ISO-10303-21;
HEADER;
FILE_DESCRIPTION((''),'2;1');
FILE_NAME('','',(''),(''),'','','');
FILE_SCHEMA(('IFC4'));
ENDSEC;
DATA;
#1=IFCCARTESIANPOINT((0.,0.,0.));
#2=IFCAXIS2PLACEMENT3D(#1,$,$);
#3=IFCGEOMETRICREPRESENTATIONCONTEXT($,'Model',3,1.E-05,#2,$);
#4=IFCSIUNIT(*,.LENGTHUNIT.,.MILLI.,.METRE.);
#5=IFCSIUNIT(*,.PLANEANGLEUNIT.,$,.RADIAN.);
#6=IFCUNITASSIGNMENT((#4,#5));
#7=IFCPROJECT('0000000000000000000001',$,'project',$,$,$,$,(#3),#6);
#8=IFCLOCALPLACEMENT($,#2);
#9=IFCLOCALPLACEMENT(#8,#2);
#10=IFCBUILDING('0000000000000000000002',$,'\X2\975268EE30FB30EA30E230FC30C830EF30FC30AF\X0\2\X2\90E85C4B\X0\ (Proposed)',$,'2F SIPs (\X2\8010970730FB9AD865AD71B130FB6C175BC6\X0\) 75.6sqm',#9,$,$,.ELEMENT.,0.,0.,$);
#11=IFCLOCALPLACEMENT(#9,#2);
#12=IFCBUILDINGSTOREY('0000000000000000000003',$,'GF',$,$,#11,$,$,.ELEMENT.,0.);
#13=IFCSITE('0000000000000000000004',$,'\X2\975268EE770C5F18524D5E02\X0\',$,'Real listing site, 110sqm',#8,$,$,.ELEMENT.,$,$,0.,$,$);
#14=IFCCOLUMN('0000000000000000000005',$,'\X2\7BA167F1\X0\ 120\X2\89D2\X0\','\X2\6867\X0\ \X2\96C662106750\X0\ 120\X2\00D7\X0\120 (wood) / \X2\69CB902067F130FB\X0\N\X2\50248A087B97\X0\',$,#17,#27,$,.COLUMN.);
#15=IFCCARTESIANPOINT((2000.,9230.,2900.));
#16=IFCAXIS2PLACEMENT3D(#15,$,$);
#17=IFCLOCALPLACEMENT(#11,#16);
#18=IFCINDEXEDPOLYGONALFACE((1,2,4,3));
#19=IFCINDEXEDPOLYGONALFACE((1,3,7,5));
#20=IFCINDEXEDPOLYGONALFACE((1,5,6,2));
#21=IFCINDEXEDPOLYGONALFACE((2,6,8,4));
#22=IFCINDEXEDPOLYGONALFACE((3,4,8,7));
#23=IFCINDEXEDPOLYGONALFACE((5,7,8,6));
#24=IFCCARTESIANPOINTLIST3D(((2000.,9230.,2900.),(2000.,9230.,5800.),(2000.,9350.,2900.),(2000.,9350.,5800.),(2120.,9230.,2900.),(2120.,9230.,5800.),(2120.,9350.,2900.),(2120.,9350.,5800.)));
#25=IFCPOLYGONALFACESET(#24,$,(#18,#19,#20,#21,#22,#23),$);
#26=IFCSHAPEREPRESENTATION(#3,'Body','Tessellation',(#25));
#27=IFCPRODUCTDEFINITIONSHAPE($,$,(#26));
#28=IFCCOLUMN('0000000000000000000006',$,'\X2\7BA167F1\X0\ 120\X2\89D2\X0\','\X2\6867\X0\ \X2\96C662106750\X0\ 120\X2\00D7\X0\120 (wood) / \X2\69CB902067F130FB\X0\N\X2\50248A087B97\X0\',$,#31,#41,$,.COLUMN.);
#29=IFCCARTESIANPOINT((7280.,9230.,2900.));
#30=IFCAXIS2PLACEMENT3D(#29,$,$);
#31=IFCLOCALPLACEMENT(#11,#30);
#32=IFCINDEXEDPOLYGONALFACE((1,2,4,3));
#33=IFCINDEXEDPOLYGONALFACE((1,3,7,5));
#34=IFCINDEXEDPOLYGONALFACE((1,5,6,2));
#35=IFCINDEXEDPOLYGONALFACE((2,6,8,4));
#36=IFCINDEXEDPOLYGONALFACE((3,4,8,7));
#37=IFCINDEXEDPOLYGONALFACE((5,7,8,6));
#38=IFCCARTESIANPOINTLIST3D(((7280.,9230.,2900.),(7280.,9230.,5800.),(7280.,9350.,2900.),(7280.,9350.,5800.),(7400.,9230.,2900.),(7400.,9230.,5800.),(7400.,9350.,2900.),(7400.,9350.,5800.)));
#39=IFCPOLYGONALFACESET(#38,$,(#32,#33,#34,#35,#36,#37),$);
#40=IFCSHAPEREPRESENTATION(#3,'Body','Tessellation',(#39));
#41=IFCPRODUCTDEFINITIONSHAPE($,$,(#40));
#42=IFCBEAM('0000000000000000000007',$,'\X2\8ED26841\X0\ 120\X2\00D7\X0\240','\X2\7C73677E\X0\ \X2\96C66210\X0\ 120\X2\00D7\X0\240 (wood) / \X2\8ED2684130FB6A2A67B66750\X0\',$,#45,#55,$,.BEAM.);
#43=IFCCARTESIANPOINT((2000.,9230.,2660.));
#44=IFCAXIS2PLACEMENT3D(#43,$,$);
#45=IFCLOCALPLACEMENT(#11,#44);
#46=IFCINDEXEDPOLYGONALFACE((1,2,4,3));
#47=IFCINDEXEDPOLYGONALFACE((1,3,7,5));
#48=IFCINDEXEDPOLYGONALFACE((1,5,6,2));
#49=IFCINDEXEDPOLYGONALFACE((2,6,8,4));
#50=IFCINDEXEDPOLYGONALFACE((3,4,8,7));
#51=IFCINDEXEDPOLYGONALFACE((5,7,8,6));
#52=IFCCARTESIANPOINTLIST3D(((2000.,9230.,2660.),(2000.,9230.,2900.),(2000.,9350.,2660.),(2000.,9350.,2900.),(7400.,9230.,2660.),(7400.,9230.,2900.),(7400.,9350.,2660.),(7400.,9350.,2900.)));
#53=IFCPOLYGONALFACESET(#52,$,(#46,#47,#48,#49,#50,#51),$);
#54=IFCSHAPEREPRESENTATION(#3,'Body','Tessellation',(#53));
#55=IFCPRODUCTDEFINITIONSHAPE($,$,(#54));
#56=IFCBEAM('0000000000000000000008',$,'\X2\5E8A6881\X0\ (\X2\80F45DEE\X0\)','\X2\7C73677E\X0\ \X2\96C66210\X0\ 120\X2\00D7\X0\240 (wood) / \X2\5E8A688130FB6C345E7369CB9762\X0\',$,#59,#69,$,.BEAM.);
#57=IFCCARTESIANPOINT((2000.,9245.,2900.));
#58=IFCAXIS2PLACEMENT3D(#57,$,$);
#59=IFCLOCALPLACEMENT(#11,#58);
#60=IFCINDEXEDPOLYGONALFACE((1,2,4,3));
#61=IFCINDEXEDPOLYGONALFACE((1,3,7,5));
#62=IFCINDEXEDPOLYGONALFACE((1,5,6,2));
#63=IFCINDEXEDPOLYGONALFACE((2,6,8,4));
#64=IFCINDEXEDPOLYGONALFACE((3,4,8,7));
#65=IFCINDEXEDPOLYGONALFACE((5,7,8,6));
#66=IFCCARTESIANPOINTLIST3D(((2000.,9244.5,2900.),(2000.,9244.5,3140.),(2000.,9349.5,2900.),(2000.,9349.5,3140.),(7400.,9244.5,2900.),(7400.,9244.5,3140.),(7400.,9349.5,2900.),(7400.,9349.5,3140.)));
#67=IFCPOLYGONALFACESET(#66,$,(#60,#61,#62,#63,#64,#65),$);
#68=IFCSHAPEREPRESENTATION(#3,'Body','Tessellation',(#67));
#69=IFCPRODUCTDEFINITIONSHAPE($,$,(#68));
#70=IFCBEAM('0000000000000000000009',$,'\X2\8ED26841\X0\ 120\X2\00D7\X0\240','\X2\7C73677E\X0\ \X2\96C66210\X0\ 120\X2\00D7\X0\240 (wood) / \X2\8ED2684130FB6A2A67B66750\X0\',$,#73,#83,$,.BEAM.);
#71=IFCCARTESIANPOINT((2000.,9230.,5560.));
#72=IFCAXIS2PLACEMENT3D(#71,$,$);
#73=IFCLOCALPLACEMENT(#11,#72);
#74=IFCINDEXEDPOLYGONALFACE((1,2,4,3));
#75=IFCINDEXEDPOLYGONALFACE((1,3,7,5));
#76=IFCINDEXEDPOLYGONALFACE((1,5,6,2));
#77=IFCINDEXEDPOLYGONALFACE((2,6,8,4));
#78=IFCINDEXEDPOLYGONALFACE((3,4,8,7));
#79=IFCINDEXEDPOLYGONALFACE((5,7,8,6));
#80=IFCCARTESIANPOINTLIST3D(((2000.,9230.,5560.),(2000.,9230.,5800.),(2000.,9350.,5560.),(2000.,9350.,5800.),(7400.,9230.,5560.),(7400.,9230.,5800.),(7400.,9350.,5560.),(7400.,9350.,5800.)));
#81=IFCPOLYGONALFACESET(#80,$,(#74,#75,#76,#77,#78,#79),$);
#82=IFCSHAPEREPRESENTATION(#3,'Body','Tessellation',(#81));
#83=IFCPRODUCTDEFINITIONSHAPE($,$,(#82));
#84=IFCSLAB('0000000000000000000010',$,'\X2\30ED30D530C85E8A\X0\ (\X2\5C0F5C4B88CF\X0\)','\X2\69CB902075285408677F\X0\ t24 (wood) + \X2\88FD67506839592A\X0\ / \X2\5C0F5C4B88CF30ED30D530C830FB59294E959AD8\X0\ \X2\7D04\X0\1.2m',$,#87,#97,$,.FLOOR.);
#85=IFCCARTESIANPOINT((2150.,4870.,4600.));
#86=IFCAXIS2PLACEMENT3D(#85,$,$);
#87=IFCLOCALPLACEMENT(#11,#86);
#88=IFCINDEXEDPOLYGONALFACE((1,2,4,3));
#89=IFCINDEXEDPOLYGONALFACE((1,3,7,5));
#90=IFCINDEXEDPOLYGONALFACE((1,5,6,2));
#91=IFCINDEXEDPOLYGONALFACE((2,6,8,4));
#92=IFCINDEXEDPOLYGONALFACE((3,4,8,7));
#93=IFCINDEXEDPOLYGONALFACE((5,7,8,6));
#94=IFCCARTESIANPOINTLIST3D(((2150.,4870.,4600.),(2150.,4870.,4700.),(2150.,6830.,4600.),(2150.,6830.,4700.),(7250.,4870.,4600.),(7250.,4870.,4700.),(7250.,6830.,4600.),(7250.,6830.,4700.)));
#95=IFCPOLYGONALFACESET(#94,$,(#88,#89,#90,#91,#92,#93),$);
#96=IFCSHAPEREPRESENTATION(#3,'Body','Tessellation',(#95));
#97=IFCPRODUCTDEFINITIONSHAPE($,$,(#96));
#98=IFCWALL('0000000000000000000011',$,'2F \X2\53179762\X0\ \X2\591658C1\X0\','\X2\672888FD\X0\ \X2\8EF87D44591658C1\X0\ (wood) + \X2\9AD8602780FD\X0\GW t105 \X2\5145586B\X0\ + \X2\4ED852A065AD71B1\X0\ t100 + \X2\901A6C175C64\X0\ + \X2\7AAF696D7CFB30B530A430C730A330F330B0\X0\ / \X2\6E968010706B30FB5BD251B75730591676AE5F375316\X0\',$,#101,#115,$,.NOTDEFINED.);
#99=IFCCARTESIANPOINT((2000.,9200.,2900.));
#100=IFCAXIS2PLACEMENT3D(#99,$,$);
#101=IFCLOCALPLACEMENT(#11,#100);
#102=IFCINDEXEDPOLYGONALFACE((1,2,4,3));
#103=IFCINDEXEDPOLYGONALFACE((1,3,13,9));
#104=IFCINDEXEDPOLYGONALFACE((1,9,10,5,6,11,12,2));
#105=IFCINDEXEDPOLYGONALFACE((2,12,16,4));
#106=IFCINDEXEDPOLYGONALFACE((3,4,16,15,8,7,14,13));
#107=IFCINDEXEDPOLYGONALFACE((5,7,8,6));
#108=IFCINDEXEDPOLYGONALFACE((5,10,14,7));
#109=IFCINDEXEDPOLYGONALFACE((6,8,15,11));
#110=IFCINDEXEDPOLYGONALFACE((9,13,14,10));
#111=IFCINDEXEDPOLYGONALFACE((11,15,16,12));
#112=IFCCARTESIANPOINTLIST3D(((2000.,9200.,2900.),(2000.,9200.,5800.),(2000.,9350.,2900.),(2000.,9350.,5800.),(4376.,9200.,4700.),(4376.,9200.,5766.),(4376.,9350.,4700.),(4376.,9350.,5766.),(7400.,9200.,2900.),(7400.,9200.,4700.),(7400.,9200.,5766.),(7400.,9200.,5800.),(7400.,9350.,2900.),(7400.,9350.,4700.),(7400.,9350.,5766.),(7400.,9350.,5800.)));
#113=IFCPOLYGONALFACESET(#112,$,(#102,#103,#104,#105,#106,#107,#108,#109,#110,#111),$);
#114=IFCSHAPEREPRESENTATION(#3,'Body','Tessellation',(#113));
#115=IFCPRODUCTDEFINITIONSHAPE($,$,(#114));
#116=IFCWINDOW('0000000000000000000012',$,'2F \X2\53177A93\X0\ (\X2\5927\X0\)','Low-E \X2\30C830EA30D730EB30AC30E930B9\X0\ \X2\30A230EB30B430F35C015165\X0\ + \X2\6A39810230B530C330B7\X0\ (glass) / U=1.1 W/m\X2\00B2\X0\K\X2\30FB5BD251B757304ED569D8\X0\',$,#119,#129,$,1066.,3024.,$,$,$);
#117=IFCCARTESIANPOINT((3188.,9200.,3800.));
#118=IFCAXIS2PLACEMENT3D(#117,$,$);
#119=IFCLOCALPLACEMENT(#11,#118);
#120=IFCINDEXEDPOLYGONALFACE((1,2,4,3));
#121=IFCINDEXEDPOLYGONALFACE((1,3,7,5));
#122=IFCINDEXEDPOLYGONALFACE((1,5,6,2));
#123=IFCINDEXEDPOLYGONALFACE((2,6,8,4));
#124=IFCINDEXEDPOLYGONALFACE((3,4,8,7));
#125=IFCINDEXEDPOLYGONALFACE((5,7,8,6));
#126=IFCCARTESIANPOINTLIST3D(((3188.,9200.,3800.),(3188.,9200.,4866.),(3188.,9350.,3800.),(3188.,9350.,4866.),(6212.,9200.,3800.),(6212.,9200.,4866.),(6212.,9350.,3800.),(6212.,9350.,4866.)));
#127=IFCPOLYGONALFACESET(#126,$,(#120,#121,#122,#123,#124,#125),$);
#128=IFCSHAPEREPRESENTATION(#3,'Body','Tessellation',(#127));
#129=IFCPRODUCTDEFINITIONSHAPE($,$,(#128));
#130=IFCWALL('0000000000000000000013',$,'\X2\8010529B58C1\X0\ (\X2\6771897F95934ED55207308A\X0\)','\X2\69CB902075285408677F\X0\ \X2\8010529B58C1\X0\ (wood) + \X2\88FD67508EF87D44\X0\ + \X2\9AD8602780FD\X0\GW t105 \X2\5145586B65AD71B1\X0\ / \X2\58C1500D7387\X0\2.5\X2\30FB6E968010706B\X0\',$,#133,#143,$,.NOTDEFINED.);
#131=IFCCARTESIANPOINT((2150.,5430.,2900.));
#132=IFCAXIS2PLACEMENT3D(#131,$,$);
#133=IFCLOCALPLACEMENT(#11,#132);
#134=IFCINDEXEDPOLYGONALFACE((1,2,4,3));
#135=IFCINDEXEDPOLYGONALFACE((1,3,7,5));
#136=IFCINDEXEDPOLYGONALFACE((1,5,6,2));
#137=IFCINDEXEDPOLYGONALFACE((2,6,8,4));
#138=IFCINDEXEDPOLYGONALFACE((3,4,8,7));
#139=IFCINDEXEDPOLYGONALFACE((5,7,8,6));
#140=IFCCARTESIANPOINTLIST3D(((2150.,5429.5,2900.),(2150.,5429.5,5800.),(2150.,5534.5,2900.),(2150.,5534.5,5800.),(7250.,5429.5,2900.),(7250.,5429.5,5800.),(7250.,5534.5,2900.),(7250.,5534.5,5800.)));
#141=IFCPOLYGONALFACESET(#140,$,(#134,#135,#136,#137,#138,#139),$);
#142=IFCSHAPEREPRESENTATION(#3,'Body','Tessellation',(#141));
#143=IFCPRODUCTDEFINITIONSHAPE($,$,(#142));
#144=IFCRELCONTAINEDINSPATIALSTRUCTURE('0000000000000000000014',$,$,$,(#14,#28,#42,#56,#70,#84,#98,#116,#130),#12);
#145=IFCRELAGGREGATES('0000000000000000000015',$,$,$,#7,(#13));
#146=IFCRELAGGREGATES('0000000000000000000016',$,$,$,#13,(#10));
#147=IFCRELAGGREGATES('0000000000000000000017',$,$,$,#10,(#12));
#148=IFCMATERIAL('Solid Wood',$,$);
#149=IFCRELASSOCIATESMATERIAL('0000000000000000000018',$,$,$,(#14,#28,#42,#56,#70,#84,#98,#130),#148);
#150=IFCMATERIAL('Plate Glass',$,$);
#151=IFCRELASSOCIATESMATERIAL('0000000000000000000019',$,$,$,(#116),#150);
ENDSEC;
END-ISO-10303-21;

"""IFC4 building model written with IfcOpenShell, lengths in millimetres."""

from ifc_helpers import new_model, si_unit, frame, frame_2d, origin, place, context, project, spatial, rectangle, extrude, material, element, fill, save


model = new_model("IFC4")

# Units and contexts
model_context = context("Model", 3, precision=1e-05, world=origin())
ifc_project = project(units=[si_unit("LENGTHUNIT", "METRE", prefix="MILLI"), si_unit("PLANEANGLEUNIT", "RADIAN")], contexts=[model_context])

# Site, building, storey
site_placement = place(None, origin())
site = spatial("IfcSite", under=ifc_project, at=site_placement, Name="青森県弘前市", ObjectType="Real listing site, 110sqm", CompositionType="ELEMENT", RefElevation=0.0)
building_placement = place(site_placement, origin())
building = spatial("IfcBuilding", under=site, at=building_placement, Name="青森・リモートワーク2部屋 (Proposed)", ObjectType="2F SIPs (耐震・高断熱・気密) 75.6sqm", CompositionType="ELEMENT", ElevationOfRefHeight=0.0, ElevationOfTerrain=0.0)
storey_placement = place(building_placement, origin())
storey = spatial("IfcBuildingStorey", under=building, at=storey_placement, Name="GF", CompositionType="ELEMENT", Elevation=0.0)

# Columns
ifc_material_1 = material(Name="Solid Wood")
column_1_placement = place(storey_placement, frame((2000.0, 9230.0, 2900.0)))
element("IfcColumn", 1, at=column_1_placement, inside=storey, material=ifc_material_1, Name="管柱 120角", Description="桧 集成材 120×120 (wood) / 構造柱・N値計算", PredefinedType="COLUMN", context=model_context, shape_type="SweptSolid", body=[
    extrude(rectangle(XDim=120.0, YDim=120.0, at=frame_2d((60.0, 60.0))), frame((2000.0, 9230.0, 2900.0)), (0.0, 0.0, 1.0), 2900.0),
])
column_2_placement = place(storey_placement, frame((7280.0, 9230.0, 2900.0)))
element("IfcColumn", 2, at=column_2_placement, inside=storey, material=ifc_material_1, Name="管柱 120角", Description="桧 集成材 120×120 (wood) / 構造柱・N値計算", PredefinedType="COLUMN", context=model_context, shape_type="SweptSolid", body=[
    extrude(rectangle(XDim=120.0, YDim=120.0, at=frame_2d((60.0, 60.0))), frame((7280.0, 9230.0, 2900.0)), (0.0, 0.0, 1.0), 2900.0),
])

# Beams
beam_1_placement = place(storey_placement, frame((2000.0, 9230.0, 2660.0)))
element("IfcBeam", 3, at=beam_1_placement, inside=storey, material=ifc_material_1, Name="軒桁 120×240", Description="米松 集成 120×240 (wood) / 軒桁・横架材", PredefinedType="BEAM", context=model_context, shape_type="SweptSolid", body=[
    extrude(rectangle(XDim=5400.0, YDim=120.0, at=frame_2d((2700.0, 60.0))), frame((2000.0, 9230.0, 2660.0)), (0.0, 0.0, 1.0), 240.0),
])
beam_2_placement = place(storey_placement, frame((2000.0, 9245.0, 2900.0)))
element("IfcBeam", 4, at=beam_2_placement, inside=storey, material=ifc_material_1, Name="床梁 (胴差)", Description="米松 集成 120×240 (wood) / 床梁・水平構面", PredefinedType="BEAM", context=model_context, shape_type="SweptSolid", body=[
    extrude(rectangle(XDim=5400.0, YDim=105.0, at=frame_2d((2700.0, 52.0))), frame((2000.0, 9245.0, 2900.0)), (0.0, 0.0, 1.0), 240.0),
])
beam_3_placement = place(storey_placement, frame((2000.0, 9230.0, 5560.0)))
element("IfcBeam", 5, at=beam_3_placement, inside=storey, material=ifc_material_1, Name="軒桁 120×240", Description="米松 集成 120×240 (wood) / 軒桁・横架材", PredefinedType="BEAM", context=model_context, shape_type="SweptSolid", body=[
    extrude(rectangle(XDim=5400.0, YDim=120.0, at=frame_2d((2700.0, 60.0))), frame((2000.0, 9230.0, 5560.0)), (0.0, 0.0, 1.0), 240.0),
])

# Slab
slab_placement = place(storey_placement, frame((2150.0, 4870.0, 4600.0)))
element("IfcSlab", 6, at=slab_placement, inside=storey, material=ifc_material_1, Name="ロフト床 (小屋裏)", Description="構造用合板 t24 (wood) + 製材根太 / 小屋裏ロフト・天井高 約1.2m", PredefinedType="FLOOR", context=model_context, shape_type="SweptSolid", body=[
    extrude(rectangle(XDim=5100.0, YDim=1960.0, at=frame_2d((2550.0, 980.0))), frame((2150.0, 4870.0, 4600.0)), (0.0, 0.0, 1.0), 100.0),
])

# Wall, opening, window
wall_1_placement = place(storey_placement, frame((2000.0, 9200.0, 2900.0)))
wall_1 = element("IfcWall", 7, at=wall_1_placement, inside=storey, material=ifc_material_1, Name="2F 北面 外壁", Description="木製 軸組外壁 (wood) + 高性能GW t105 充填 + 付加断熱 t100 + 通気層 + 窯業系サイディング / 準耐火・寒冷地外皮強化", PredefinedType="NOTDEFINED", context=model_context, shape_type="SweptSolid", body=[
    extrude(rectangle(XDim=5400.0, YDim=150.0, at=frame_2d((2700.0, 75.0))), frame((2000.0, 9200.0, 2900.0)), (0.0, 0.0, 1.0), 2900.0),
])
opening_1_placement = place(storey_placement, frame((3188.0, 9200.0, 3800.0)))
opening_1 = element("IfcOpeningElement", 8, at=opening_1_placement, cuts=wall_1, PredefinedType="NOTDEFINED", context=model_context, shape_type="SweptSolid", body=[
    extrude(rectangle(XDim=3024.0, YDim=150.0, at=frame_2d((1512.0, 75.0))), frame((3188.0, 9200.0, 3800.0)), (0.0, 0.0, 1.0), 1066.0),
])
ifc_material_2 = material(Name="Plate Glass")
window_1_placement = place(storey_placement, frame((3188.0, 9200.0, 3800.0)))
window_1 = element("IfcWindow", 9, at=window_1_placement, inside=storey, material=ifc_material_2, Name="2F 北窓 (大)", Description="Low-E トリプルガラス アルゴン封入 + 樹脂サッシ (glass) / U=1.1 W/m²K・寒冷地仕様", OverallHeight=1066.0, OverallWidth=3024.0, context=model_context, shape_type="SweptSolid", body=[
    extrude(rectangle(XDim=3024.0, YDim=150.0, at=frame_2d((1512.0, 75.0))), frame((3188.0, 9200.0, 3800.0)), (0.0, 0.0, 1.0), 1066.0),
])
fill(opening_1, window_1)

# Wall
wall_2_placement = place(storey_placement, frame((2150.0, 5430.0, 2900.0)))
element("IfcWall", 10, at=wall_2_placement, inside=storey, material=ifc_material_1, Name="耐力壁 (東西間仕切り)", Description="構造用合板 耐力壁 (wood) + 製材軸組 + 高性能GW t105 充填断熱 / 壁倍率2.5・準耐火", PredefinedType="NOTDEFINED", context=model_context, shape_type="SweptSolid", body=[
    extrude(rectangle(XDim=5100.0, YDim=105.0, at=frame_2d((2550.0, 52.0))), frame((2150.0, 5430.0, 2900.0)), (0.0, 0.0, 1.0), 2900.0),
])

save(model, "model.ifc")
